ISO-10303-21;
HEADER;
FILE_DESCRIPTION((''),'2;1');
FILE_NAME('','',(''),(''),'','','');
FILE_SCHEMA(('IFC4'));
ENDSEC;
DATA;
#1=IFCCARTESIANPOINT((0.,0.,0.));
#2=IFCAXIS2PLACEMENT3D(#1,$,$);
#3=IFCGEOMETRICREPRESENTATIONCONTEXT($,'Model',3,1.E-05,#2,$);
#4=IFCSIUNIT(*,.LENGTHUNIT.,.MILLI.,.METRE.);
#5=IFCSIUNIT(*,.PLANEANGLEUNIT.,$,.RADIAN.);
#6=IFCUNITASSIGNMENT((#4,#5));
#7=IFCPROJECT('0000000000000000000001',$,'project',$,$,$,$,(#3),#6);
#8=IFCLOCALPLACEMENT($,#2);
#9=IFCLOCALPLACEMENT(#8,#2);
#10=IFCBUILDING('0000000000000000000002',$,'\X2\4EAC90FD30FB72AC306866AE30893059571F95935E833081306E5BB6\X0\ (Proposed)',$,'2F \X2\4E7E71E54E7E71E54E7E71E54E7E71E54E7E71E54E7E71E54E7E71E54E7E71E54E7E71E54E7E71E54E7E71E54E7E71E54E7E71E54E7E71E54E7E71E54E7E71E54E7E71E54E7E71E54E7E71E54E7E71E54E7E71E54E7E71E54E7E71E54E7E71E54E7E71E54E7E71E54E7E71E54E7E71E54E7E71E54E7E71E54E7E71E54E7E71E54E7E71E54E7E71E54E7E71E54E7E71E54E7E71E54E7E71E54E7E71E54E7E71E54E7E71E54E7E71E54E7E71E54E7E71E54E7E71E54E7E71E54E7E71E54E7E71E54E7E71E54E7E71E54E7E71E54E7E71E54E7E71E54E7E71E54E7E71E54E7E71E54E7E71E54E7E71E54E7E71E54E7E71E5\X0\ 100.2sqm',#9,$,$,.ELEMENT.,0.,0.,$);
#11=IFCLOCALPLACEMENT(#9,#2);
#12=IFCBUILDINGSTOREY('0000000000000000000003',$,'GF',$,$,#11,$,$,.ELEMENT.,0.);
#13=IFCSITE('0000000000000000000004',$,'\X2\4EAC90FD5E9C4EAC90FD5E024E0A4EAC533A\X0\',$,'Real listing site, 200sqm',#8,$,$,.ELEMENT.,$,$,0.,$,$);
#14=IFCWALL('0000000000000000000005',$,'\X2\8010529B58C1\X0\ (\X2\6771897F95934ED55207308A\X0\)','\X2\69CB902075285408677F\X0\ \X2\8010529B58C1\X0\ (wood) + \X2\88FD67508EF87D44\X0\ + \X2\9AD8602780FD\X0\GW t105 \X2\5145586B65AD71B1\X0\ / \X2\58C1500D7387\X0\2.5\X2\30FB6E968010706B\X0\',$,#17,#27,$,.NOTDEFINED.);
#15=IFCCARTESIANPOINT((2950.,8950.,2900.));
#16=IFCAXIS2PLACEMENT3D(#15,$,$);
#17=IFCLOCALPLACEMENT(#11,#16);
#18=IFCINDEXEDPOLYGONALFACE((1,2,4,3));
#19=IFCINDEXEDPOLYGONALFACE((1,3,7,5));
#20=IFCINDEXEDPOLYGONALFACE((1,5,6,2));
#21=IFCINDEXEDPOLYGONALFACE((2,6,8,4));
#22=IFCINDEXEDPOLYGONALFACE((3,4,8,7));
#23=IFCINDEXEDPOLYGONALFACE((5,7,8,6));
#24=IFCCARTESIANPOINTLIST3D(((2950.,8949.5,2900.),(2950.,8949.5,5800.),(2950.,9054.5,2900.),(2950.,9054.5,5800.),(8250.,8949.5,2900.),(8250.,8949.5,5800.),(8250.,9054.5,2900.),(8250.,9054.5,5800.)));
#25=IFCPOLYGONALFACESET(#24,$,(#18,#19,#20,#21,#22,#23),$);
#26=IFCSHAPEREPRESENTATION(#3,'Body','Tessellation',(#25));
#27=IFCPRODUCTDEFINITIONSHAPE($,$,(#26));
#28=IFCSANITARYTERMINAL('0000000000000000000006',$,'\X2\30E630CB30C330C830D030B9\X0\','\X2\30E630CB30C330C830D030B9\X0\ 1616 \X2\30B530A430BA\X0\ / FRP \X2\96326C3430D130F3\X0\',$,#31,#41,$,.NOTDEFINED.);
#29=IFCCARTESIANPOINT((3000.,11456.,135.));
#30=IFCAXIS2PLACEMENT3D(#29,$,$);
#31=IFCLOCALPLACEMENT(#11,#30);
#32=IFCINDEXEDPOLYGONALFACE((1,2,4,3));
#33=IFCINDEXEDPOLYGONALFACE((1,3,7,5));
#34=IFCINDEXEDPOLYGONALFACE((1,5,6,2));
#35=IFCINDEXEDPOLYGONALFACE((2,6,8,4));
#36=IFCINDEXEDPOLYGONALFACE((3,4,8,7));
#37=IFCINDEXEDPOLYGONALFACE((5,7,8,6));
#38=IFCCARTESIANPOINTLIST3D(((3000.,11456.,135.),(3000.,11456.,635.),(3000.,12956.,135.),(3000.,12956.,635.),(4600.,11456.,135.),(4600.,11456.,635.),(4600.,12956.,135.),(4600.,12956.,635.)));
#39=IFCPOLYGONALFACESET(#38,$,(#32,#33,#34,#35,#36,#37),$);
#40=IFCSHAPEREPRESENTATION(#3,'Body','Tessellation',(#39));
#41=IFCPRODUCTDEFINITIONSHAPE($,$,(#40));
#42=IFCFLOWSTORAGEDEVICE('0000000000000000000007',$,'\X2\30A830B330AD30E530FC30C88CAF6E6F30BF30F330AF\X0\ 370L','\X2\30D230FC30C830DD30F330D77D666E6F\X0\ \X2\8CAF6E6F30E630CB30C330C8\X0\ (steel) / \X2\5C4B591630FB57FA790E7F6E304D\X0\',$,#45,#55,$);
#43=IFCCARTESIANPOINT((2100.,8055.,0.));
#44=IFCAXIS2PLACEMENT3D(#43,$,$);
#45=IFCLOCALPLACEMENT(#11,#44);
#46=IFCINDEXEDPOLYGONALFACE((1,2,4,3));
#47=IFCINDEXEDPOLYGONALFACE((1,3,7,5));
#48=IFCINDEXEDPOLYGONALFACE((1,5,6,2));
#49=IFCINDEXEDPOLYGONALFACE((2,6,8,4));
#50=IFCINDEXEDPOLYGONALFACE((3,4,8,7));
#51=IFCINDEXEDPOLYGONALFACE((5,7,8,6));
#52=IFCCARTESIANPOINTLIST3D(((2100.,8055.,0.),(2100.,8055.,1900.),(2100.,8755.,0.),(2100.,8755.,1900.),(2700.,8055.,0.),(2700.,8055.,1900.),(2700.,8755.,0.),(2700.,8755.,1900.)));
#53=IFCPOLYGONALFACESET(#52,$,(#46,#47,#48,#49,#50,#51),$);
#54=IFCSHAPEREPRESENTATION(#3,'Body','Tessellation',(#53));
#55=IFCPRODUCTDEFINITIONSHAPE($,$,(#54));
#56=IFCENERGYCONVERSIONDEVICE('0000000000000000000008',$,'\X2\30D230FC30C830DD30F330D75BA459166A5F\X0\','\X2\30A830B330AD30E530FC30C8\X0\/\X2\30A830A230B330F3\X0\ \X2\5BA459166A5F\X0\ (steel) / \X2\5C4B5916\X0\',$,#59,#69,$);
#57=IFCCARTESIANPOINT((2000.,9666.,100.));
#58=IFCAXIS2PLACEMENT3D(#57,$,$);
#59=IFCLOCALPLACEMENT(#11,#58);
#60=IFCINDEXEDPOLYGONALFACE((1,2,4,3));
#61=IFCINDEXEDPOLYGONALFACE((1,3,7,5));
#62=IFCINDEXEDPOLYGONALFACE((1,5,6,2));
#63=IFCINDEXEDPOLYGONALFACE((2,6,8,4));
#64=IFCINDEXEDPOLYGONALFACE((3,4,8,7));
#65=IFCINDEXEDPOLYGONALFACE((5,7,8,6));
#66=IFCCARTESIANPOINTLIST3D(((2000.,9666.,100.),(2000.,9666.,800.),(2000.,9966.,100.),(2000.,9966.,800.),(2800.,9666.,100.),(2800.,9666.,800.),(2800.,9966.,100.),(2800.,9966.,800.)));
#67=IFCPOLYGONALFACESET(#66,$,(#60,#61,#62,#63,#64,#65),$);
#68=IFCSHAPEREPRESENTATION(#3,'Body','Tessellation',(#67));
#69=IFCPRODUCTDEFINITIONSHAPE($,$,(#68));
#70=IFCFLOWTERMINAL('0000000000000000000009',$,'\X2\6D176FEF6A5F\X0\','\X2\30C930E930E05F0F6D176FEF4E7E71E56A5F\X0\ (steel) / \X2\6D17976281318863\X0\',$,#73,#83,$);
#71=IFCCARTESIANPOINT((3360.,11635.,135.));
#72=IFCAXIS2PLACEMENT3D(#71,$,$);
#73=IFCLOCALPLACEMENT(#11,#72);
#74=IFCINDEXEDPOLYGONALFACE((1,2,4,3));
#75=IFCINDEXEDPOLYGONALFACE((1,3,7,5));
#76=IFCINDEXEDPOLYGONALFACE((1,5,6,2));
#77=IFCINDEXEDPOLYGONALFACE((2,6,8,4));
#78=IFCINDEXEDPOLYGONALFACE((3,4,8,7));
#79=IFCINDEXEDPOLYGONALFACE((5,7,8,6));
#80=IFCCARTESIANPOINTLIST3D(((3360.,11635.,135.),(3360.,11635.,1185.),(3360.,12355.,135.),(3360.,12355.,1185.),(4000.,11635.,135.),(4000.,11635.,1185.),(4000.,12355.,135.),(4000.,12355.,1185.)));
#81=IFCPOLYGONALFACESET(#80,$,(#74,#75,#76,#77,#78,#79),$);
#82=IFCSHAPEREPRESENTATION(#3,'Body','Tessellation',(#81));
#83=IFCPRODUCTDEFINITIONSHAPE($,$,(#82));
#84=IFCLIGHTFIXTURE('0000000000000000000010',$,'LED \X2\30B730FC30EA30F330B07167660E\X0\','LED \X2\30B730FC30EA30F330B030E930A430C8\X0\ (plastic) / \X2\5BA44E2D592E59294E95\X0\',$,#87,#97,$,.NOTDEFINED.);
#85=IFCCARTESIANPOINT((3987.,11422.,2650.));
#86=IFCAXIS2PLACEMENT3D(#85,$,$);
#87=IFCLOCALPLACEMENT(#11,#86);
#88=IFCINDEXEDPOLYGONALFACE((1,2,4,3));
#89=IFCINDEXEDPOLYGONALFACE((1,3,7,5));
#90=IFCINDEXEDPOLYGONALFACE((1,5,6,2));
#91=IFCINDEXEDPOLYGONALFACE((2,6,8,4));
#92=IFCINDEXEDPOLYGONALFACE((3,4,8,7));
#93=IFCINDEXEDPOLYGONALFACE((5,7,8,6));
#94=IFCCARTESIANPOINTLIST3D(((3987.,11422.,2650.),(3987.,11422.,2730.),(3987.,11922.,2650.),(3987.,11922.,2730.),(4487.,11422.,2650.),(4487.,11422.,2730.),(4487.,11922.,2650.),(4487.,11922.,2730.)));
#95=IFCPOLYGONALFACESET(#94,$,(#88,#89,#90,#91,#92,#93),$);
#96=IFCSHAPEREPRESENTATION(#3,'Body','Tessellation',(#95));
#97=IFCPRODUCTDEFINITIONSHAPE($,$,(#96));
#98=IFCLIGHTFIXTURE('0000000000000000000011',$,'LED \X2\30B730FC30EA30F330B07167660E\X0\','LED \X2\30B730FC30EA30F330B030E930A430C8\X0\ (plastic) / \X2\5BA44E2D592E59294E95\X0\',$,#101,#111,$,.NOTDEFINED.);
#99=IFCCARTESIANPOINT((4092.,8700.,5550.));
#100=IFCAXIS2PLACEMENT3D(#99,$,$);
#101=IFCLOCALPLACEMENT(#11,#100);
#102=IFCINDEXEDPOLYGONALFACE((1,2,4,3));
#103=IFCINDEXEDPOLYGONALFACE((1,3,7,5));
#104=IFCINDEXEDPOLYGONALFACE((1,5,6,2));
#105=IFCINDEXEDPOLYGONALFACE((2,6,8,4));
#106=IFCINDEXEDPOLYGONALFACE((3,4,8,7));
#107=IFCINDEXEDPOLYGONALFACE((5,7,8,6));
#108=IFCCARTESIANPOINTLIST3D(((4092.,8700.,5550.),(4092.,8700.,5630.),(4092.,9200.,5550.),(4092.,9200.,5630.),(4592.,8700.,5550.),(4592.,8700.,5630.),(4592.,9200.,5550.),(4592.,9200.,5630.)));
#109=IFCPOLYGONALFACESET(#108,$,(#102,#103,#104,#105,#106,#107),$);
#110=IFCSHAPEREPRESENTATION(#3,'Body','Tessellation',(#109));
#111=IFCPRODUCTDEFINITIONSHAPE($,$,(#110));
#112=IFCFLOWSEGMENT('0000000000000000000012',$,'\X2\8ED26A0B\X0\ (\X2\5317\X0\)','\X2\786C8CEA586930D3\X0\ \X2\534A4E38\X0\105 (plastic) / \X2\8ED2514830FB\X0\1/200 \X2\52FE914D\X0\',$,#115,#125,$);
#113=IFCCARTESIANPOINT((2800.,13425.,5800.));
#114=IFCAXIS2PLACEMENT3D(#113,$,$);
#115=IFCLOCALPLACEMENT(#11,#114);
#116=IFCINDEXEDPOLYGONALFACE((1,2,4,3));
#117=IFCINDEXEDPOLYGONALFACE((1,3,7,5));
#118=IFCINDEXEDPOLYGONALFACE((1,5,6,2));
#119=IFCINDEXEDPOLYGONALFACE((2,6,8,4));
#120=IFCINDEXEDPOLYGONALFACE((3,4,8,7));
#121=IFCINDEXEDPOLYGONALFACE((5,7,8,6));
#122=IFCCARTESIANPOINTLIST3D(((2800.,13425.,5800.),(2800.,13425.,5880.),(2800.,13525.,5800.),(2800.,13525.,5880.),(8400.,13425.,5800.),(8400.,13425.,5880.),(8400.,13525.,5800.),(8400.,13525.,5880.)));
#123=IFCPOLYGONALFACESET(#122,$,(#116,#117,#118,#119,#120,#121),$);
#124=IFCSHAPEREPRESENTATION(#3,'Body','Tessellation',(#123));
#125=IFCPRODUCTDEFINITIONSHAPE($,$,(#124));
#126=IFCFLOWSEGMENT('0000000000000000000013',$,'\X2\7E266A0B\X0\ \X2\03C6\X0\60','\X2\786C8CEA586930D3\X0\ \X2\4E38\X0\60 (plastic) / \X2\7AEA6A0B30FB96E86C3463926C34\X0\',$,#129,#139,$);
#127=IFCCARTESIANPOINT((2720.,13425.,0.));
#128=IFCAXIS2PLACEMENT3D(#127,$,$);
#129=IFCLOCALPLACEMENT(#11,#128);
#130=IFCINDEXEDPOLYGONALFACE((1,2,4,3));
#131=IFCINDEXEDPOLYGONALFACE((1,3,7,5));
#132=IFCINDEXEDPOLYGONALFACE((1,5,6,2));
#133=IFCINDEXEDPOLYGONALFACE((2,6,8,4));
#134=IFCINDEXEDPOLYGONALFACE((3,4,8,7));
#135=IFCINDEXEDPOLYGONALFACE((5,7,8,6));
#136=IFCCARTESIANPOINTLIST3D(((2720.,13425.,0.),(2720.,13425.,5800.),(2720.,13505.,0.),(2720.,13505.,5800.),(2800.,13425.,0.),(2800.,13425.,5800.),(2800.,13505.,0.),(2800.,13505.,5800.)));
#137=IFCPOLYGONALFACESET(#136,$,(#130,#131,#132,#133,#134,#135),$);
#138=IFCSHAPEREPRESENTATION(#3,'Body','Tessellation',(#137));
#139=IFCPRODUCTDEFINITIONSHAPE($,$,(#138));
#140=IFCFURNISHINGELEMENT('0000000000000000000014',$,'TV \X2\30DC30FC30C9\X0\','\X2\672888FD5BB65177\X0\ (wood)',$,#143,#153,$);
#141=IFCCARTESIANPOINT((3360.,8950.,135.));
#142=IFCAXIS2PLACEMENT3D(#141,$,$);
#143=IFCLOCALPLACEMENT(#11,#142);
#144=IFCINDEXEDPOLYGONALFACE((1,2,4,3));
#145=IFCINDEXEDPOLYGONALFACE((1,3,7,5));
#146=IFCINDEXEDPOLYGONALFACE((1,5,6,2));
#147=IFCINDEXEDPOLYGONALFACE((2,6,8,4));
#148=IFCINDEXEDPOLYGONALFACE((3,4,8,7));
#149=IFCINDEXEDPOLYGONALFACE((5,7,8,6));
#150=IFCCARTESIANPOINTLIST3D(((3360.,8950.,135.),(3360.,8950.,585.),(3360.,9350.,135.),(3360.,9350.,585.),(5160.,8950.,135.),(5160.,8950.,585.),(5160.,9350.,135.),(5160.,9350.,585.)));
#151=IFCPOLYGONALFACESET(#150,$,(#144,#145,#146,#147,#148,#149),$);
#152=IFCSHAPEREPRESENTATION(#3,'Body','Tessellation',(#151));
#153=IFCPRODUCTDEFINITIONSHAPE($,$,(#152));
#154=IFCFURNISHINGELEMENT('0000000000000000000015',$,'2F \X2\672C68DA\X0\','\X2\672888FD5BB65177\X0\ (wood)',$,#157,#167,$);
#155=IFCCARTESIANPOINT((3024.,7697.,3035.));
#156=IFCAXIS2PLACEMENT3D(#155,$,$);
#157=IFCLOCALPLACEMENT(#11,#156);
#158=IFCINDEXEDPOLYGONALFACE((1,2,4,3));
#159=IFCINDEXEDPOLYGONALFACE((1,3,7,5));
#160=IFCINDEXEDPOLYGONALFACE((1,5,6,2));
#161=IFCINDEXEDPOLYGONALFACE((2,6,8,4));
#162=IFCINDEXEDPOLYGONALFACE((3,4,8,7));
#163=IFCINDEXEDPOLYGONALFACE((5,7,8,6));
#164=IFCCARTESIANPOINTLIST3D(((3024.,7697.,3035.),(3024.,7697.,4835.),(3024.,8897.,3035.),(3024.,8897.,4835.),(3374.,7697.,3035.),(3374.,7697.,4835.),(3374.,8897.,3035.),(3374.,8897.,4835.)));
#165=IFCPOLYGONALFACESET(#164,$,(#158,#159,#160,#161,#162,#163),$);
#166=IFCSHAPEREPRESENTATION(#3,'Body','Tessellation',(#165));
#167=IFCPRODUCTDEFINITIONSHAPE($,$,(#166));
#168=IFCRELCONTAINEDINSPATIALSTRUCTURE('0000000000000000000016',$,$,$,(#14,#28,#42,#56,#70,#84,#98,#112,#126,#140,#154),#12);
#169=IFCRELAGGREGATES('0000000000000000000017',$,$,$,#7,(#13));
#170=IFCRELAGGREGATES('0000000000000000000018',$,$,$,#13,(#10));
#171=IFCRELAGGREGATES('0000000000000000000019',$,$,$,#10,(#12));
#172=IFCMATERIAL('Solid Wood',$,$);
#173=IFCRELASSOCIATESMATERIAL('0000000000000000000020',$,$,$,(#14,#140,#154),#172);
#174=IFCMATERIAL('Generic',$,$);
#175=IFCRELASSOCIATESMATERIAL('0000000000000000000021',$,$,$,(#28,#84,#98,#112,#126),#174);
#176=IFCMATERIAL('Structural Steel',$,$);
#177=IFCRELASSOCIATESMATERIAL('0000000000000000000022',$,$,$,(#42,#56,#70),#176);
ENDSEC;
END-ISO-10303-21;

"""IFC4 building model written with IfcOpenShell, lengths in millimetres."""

from ifc_helpers import new_model, si_unit, frame, frame_2d, origin, place, context, project, spatial, rectangle, extrude, material, element, save


model = new_model("IFC4")

# Units and contexts
model_context = context("Model", 3, precision=1e-05, world=origin())
ifc_project = project(units=[si_unit("LENGTHUNIT", "METRE", prefix="MILLI"), si_unit("PLANEANGLEUNIT", "RADIAN")], contexts=[model_context])

# Site, building, storey
site_placement = place(None, origin())
site = spatial("IfcSite", under=ifc_project, at=site_placement, Name="京都府京都市上京区", ObjectType="Real listing site, 200sqm", CompositionType="ELEMENT", RefElevation=0.0)
building_placement = place(site_placement, origin())
building = spatial("IfcBuilding", under=site, at=building_placement, Name="京都・犬と暮らす土間広めの家 (Proposed)", ObjectType="2F 乾燥乾燥乾燥乾燥乾燥乾燥乾燥乾燥乾燥乾燥乾燥乾燥乾燥乾燥乾燥乾燥乾燥乾燥乾燥乾燥乾燥乾燥乾燥乾燥乾燥乾燥乾燥乾燥乾燥乾燥乾燥乾燥乾燥乾燥乾燥乾燥乾燥乾燥乾燥乾燥乾燥乾燥乾燥乾燥乾燥乾燥乾燥乾燥乾燥乾燥乾燥乾燥乾燥乾燥乾燥乾燥乾燥乾燥乾燥乾燥 100.2sqm", CompositionType="ELEMENT", ElevationOfRefHeight=0.0, ElevationOfTerrain=0.0)
storey_placement = place(building_placement, origin())
storey = spatial("IfcBuildingStorey", under=building, at=storey_placement, Name="GF", CompositionType="ELEMENT", Elevation=0.0)

# Shared definitions
ifc_material_1 = material(Name="Solid Wood")

# Wall
wall_1_placement = place(storey_placement, frame((2950.0, 8950.0, 2900.0)))
element("IfcWall", 1, at=wall_1_placement, inside=storey, material=ifc_material_1, Name="耐力壁 (東西間仕切り)", Description="構造用合板 耐力壁 (wood) + 製材軸組 + 高性能GW t105 充填断熱 / 壁倍率2.5・準耐火", PredefinedType="NOTDEFINED", context=model_context, shape_type="SweptSolid", body=[
    extrude(rectangle(XDim=5300.0, YDim=105.0, at=frame_2d((2650.0, 52.0))), frame((2950.0, 8950.0, 2900.0)), (0.0, 0.0, 1.0), 2900.0),
])

# Sanitary terminal
ifc_material_2 = material(Name="Generic")
sanitary_terminal_placement = place(storey_placement, frame((3000.0, 11456.0, 135.0)))
element("IfcSanitaryTerminal", 2, at=sanitary_terminal_placement, inside=storey, material=ifc_material_2, Name="ユニットバス", Description="ユニットバス 1616 サイズ / FRP 防水パン", PredefinedType="NOTDEFINED", context=model_context, shape_type="SweptSolid", body=[
    extrude(rectangle(XDim=1600.0, YDim=1500.0, at=frame_2d((800.0, 750.0))), frame((3000.0, 11456.0, 135.0)), (0.0, 0.0, 1.0), 500.0),
])

# Flow storage device
ifc_material_3 = material(Name="Structural Steel")
flow_storage_device_placement = place(storey_placement, frame((2100.0, 8055.0, 0.0)))
element("IfcFlowStorageDevice", 3, at=flow_storage_device_placement, inside=storey, material=ifc_material_3, Name="エコキュート貯湯タンク 370L", Description="ヒートポンプ給湯 貯湯ユニット (steel) / 屋外・基礎置き", context=model_context, shape_type="SweptSolid", body=[
    extrude(rectangle(XDim=600.0, YDim=700.0, at=frame_2d((300.0, 350.0))), frame((2100.0, 8055.0, 0.0)), (0.0, 0.0, 1.0), 1900.0),
])

# Energy conversion device
energy_conversion_device_placement = place(storey_placement, frame((2000.0, 9666.0, 100.0)))
element("IfcEnergyConversionDevice", 4, at=energy_conversion_device_placement, inside=storey, material=ifc_material_3, Name="ヒートポンプ室外機", Description="エコキュート/エアコン 室外機 (steel) / 屋外", context=model_context, shape_type="SweptSolid", body=[
    extrude(rectangle(XDim=800.0, YDim=300.0, at=frame_2d((400.0, 150.0))), frame((2000.0, 9666.0, 100.0)), (0.0, 0.0, 1.0), 700.0),
])

# Flow terminal
flow_terminal_placement = place(storey_placement, frame((3360.0, 11635.0, 135.0)))
element("IfcFlowTerminal", 5, at=flow_terminal_placement, inside=storey, material=ifc_material_3, Name="洗濯機", Description="ドラム式洗濯乾燥機 (steel) / 洗面脱衣", context=model_context, shape_type="SweptSolid", body=[
    extrude(rectangle(XDim=640.0, YDim=720.0, at=frame_2d((320.0, 360.0))), frame((3360.0, 11635.0, 135.0)), (0.0, 0.0, 1.0), 1050.0),
])

# Light fixtures
light_fixture_1_placement = place(storey_placement, frame((3987.0, 11422.0, 2650.0)))
element("IfcLightFixture", 6, at=light_fixture_1_placement, inside=storey, material=ifc_material_2, Name="LED シーリング照明", Description="LED シーリングライト (plastic) / 室中央天井", PredefinedType="NOTDEFINED", context=model_context, shape_type="SweptSolid", body=[
    extrude(rectangle(XDim=500.0, YDim=500.0, at=frame_2d((250.0, 250.0))), frame((3987.0, 11422.0, 2650.0)), (0.0, 0.0, 1.0), 80.0),
])
light_fixture_2_placement = place(storey_placement, frame((4092.0, 8700.0, 5550.0)))
element("IfcLightFixture", 7, at=light_fixture_2_placement, inside=storey, material=ifc_material_2, Name="LED シーリング照明", Description="LED シーリングライト (plastic) / 室中央天井", PredefinedType="NOTDEFINED", context=model_context, shape_type="SweptSolid", body=[
    extrude(rectangle(XDim=500.0, YDim=500.0, at=frame_2d((250.0, 250.0))), frame((4092.0, 8700.0, 5550.0)), (0.0, 0.0, 1.0), 80.0),
])

# Flow segments
flow_segment_1_placement = place(storey_placement, frame((2800.0, 13425.0, 5800.0)))
element("IfcFlowSegment", 8, at=flow_segment_1_placement, inside=storey, material=ifc_material_2, Name="軒樋 (北)", Description="硬質塩ビ 半丸105 (plastic) / 軒先・1/200 勾配", context=model_context, shape_type="SweptSolid", body=[
    extrude(rectangle(XDim=5600.0, YDim=100.0, at=frame_2d((2800.0, 50.0))), frame((2800.0, 13425.0, 5800.0)), (0.0, 0.0, 1.0), 80.0),
])
flow_segment_2_placement = place(storey_placement, frame((2720.0, 13425.0, 0.0)))
element("IfcFlowSegment", 9, at=flow_segment_2_placement, inside=storey, material=ifc_material_2, Name="縦樋 φ60", Description="硬質塩ビ 丸60 (plastic) / 竪樋・雨水排水", context=model_context, shape_type="SweptSolid", body=[
    extrude(rectangle(XDim=80.0, YDim=80.0, at=frame_2d((40.0, 40.0))), frame((2720.0, 13425.0, 0.0)), (0.0, 0.0, 1.0), 5800.0),
])

# Furnishing elements
furnishing_1_placement = place(storey_placement, frame((3360.0, 8950.0, 135.0)))
element("IfcFurnishingElement", 10, at=furnishing_1_placement, inside=storey, material=ifc_material_1, Name="TV ボード", Description="木製家具 (wood)", context=model_context, shape_type="SweptSolid", body=[
    extrude(rectangle(XDim=1800.0, YDim=400.0, at=frame_2d((900.0, 200.0))), frame((3360.0, 8950.0, 135.0)), (0.0, 0.0, 1.0), 450.0),
])
furnishing_2_placement = place(storey_placement, frame((3024.0, 7697.0, 3035.0)))
element("IfcFurnishingElement", 11, at=furnishing_2_placement, inside=storey, material=ifc_material_1, Name="2F 本棚", Description="木製家具 (wood)", context=model_context, shape_type="SweptSolid", body=[
    extrude(rectangle(XDim=350.0, YDim=1200.0, at=frame_2d((175.0, 600.0))), frame((3024.0, 7697.0, 3035.0)), (0.0, 0.0, 1.0), 1800.0),
])

save(model, "model.ifc")
